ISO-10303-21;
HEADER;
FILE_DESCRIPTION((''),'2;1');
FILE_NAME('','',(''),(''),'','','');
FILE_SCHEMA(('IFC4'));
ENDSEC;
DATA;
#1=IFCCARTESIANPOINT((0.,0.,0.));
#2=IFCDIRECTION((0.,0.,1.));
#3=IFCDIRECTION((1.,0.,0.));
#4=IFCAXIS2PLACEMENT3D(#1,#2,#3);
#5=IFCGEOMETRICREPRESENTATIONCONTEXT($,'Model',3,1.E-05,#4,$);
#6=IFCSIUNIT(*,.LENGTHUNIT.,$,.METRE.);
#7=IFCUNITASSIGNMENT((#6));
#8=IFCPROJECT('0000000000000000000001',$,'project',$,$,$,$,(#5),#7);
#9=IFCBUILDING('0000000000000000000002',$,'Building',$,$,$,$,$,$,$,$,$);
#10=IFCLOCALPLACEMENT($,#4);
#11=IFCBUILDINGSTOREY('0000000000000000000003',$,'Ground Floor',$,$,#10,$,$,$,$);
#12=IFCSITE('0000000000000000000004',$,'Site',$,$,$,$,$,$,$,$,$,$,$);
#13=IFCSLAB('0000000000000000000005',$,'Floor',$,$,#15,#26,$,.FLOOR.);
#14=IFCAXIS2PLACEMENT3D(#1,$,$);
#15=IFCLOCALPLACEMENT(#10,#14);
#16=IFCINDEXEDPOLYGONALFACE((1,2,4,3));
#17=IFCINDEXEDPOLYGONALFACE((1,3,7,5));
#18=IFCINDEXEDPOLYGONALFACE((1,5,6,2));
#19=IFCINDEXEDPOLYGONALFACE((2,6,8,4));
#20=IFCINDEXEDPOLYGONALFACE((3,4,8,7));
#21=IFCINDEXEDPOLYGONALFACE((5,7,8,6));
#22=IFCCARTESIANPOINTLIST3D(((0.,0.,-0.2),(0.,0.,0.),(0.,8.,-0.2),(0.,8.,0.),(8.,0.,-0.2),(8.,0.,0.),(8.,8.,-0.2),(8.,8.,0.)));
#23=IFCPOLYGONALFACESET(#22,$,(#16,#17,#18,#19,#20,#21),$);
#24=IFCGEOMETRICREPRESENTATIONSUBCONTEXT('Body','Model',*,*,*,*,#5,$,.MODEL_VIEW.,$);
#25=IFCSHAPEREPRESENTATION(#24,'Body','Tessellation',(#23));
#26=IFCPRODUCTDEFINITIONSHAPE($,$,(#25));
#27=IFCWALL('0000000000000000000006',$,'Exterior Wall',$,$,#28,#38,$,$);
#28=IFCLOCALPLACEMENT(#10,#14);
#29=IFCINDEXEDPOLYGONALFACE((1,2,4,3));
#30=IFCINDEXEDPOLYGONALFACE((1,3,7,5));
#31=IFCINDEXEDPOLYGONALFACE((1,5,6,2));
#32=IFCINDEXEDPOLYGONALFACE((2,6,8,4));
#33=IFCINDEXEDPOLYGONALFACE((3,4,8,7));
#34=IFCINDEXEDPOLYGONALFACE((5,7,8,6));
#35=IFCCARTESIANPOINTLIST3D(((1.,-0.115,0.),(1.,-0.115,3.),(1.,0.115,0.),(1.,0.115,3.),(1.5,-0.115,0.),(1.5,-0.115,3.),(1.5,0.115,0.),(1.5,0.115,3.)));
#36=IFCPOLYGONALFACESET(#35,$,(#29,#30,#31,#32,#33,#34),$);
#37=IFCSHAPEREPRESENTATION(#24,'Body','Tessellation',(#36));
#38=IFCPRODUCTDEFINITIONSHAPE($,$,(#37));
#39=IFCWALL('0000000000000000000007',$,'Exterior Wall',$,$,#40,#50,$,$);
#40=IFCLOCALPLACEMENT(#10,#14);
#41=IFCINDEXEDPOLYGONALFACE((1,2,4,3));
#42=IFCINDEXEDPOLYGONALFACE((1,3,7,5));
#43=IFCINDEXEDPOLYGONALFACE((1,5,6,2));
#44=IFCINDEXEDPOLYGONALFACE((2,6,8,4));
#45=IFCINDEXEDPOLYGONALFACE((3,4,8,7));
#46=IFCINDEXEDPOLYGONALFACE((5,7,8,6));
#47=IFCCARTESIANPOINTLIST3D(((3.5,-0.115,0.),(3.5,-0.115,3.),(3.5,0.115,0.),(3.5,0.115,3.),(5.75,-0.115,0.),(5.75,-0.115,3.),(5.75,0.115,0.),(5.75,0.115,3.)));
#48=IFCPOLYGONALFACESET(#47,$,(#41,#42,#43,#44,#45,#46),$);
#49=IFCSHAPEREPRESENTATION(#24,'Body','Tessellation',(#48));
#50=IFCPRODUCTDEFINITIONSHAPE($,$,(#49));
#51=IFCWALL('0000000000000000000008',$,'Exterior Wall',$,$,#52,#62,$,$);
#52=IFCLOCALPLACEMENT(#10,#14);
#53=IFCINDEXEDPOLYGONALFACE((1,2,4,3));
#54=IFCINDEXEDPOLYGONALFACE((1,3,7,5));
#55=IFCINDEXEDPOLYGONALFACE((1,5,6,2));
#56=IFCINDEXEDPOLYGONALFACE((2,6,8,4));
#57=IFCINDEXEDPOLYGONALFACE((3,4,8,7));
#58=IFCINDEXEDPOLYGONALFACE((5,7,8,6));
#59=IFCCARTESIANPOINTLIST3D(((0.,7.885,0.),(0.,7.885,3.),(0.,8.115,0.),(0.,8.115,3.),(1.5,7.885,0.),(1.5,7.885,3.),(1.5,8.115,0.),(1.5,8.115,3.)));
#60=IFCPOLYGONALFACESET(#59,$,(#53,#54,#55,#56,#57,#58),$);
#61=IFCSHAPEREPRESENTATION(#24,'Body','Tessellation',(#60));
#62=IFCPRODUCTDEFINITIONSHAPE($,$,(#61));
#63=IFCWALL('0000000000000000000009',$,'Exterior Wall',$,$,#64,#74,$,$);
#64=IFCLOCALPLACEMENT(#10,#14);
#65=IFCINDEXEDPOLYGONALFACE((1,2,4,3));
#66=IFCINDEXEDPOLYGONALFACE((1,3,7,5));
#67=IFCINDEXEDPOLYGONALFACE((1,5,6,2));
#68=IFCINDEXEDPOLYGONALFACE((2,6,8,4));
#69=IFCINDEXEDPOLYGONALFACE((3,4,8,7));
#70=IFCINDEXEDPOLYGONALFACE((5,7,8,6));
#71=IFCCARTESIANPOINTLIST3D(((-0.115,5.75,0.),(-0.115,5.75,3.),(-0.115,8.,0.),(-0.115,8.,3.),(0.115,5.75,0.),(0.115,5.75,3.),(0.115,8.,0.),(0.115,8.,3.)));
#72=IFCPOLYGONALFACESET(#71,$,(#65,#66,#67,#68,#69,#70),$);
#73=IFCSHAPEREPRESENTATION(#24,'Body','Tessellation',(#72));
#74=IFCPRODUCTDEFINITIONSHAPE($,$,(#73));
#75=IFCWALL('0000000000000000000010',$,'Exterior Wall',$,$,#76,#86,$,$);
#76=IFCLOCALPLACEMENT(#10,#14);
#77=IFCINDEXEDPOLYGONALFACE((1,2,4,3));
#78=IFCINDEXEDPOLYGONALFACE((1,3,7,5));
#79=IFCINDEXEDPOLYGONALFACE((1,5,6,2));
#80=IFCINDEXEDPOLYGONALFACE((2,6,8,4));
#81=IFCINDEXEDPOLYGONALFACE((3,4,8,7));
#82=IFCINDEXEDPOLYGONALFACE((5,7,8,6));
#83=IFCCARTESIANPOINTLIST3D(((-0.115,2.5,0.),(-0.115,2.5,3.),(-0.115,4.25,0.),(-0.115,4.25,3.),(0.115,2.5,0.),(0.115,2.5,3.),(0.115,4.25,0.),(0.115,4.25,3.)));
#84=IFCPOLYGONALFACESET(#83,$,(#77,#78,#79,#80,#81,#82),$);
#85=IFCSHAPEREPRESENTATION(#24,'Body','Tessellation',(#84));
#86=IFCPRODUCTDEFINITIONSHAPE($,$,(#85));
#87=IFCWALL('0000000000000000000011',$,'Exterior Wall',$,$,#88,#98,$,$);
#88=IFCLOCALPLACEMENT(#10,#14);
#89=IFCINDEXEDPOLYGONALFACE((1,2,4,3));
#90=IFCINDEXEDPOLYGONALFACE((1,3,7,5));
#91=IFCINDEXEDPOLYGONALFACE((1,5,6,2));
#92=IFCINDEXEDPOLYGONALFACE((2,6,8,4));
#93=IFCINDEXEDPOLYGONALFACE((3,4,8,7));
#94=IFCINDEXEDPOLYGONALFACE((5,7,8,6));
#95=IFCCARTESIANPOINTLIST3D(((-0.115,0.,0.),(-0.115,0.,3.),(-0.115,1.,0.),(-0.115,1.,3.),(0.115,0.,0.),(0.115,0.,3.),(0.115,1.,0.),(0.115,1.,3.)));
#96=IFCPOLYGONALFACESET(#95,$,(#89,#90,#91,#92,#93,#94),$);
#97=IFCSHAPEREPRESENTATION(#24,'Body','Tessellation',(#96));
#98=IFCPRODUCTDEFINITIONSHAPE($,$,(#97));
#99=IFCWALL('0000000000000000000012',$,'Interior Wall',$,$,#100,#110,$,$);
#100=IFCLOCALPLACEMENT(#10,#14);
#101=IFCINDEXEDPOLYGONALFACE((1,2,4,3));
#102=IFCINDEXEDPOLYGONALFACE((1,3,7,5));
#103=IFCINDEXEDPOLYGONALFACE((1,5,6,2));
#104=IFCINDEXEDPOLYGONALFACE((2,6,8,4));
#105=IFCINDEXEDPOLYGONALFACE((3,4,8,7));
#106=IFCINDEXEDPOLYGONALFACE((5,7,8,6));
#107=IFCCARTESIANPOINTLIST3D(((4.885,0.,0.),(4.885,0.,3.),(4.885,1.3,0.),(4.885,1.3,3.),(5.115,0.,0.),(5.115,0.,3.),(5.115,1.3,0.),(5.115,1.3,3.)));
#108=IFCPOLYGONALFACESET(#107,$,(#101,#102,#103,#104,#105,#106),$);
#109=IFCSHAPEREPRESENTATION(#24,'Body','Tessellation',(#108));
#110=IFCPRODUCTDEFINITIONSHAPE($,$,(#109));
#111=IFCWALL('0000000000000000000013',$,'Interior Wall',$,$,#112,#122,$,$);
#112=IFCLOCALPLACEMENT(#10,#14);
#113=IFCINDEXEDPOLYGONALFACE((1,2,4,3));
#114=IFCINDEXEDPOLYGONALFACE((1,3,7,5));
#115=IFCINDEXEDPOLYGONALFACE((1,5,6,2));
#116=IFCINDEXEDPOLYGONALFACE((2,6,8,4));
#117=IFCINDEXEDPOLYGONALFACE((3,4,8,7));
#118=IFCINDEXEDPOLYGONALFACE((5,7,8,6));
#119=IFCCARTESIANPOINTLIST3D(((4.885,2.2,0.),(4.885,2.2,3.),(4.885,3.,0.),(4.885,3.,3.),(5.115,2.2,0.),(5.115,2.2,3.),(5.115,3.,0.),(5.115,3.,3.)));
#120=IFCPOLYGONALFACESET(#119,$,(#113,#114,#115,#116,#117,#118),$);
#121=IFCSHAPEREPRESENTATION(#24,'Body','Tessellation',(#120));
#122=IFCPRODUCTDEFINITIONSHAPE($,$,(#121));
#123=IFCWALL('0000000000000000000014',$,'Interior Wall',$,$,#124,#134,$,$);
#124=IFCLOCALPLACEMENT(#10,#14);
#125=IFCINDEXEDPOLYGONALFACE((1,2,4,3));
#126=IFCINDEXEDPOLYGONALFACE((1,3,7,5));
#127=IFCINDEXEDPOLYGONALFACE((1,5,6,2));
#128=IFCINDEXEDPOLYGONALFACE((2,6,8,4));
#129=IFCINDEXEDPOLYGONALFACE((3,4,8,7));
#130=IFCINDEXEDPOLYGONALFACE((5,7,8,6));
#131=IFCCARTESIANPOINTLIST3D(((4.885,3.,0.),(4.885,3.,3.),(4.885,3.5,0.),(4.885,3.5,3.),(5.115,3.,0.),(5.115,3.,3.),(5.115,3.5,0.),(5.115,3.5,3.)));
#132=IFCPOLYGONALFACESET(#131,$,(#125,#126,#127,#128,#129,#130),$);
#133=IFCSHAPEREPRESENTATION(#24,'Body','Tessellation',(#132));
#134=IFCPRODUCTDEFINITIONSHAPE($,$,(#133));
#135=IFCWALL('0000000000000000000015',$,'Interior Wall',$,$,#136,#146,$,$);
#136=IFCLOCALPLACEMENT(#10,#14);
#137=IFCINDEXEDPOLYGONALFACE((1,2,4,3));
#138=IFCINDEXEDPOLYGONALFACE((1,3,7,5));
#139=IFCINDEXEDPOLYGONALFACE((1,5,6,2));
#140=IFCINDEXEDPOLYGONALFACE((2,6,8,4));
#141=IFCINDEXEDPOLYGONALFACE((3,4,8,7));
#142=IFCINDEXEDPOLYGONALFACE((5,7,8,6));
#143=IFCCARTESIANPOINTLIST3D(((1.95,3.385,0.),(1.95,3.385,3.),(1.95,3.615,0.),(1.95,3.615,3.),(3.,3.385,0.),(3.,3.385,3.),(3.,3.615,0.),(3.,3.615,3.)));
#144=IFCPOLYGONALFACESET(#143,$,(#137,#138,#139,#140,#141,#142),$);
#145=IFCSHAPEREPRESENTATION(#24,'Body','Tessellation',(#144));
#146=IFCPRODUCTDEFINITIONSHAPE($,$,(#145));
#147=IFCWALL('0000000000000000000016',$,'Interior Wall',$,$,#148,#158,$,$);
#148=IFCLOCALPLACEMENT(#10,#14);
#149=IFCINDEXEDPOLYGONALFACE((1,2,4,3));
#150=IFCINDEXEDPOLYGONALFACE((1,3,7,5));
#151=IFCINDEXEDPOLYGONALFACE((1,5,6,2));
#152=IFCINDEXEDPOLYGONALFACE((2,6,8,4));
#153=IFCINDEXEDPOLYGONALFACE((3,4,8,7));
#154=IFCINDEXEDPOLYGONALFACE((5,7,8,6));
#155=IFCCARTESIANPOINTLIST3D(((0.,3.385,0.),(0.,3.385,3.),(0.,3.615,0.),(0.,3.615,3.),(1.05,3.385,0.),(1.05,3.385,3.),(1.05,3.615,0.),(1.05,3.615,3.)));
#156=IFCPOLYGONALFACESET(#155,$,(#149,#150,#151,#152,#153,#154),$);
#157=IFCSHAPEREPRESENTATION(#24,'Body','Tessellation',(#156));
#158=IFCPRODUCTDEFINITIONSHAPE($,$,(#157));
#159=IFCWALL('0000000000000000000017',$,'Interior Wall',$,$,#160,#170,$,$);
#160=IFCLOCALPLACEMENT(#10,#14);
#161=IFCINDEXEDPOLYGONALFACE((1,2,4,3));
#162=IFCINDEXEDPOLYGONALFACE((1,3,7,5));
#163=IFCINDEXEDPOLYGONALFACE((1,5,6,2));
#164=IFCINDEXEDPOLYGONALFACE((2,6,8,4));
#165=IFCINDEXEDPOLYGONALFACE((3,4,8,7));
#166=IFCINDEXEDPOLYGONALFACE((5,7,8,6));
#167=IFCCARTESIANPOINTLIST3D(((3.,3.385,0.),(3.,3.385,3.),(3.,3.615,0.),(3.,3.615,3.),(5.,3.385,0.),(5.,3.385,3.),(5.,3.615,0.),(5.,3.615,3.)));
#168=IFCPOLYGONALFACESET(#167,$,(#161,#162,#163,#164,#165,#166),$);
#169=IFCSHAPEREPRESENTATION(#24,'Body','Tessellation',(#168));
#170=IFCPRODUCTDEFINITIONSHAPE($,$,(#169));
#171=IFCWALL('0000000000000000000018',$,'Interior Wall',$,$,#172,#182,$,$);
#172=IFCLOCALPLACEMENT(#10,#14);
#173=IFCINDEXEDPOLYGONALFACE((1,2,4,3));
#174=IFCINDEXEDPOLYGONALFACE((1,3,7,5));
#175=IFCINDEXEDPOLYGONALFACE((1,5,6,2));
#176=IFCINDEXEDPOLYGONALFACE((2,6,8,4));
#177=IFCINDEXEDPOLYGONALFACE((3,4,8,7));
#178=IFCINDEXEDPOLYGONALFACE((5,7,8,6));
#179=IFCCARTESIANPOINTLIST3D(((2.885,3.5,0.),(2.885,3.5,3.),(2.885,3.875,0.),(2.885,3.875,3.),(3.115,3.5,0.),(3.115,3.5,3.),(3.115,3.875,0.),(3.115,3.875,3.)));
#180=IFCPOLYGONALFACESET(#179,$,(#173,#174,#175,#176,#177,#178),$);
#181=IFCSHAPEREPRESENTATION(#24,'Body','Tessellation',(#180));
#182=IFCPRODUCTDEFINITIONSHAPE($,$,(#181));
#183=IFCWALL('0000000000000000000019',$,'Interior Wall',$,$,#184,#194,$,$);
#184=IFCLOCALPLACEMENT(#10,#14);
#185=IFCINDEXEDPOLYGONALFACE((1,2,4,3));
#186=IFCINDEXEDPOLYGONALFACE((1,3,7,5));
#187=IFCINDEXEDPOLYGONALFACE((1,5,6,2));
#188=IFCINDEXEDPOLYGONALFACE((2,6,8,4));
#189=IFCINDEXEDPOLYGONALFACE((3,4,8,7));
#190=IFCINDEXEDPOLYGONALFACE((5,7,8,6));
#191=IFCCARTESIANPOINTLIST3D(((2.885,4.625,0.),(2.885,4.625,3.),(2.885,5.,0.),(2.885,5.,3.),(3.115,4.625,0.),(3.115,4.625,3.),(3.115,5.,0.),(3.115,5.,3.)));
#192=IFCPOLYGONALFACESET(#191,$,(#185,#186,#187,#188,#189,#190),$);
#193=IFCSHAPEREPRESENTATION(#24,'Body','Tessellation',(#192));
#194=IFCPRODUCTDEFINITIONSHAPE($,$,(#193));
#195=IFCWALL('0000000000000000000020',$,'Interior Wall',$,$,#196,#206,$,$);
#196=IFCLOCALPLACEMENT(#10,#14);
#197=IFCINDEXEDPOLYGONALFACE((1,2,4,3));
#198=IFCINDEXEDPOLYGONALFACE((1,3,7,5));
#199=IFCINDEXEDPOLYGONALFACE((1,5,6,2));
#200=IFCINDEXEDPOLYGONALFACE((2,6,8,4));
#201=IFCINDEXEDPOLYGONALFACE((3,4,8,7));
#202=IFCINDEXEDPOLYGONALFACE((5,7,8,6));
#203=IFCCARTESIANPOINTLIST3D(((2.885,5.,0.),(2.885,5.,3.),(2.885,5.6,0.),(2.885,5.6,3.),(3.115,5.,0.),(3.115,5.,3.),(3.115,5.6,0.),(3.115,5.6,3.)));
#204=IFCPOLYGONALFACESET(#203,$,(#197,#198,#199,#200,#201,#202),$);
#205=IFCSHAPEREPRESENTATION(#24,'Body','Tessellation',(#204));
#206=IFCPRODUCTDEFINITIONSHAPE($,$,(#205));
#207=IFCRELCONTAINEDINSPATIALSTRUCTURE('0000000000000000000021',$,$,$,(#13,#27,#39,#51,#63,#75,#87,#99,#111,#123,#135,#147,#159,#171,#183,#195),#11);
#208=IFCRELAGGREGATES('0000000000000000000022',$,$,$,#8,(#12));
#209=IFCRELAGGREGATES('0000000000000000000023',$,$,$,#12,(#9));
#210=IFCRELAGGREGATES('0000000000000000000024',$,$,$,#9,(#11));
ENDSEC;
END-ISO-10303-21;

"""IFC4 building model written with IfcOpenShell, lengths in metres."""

from ifc_helpers import new_model, si_unit, frame, origin_with_axes, place, context, subcontext, project, spatial, indexed_curve, outline, extrude, element, save


model = new_model("IFC4")

# Units and contexts
model_context = context("Model", 3, precision=1e-05, world=origin_with_axes())
body_context = subcontext(model_context, "Body", "Model", "MODEL_VIEW")
ifc_project = project(units=[si_unit("LENGTHUNIT", "METRE")], contexts=[model_context])

# Site, building, storey
site = spatial("IfcSite", under=ifc_project, Name="Site")
building = spatial("IfcBuilding", under=site, Name="Building")
storey_placement = place(None, origin_with_axes())
storey = spatial("IfcBuildingStorey", under=building, at=storey_placement, Name="Ground Floor")

# Slab
slab_placement = place(storey_placement, frame((0.0, 0.0, -0.2), z_axis=(0.0, 0.0, 1.0), x_axis=(1.0, 0.0, 0.0)))
element("IfcSlab", 1, at=slab_placement, inside=storey, Name="Floor", PredefinedType="FLOOR", context=body_context, shape_type="SweptSolid", body=[
    extrude(outline(indexed_curve([(0.0, 0.0), (8.0, 0.0), (8.0, 8.0), (0.0, 8.0)])), None, (0.0, 0.0, 1.0), 0.2),
])

# Walls
wall_1_placement = place(storey_placement, frame((1.0, 0.0, 0.0), z_axis=(0.0, 0.0, 1.0), x_axis=(1.0, 0.0, 0.0)))
element("IfcWall", 2, at=wall_1_placement, inside=storey, Name="Exterior Wall", context=body_context, shape_type="SweptSolid", body=[
    extrude(outline(indexed_curve([(0.0, 0.0), (0.0, 0.23), (0.5, 0.23), (0.5, 0.0), (0.0, 0.0)], self_intersect=False)), frame((0.0, -0.115, 0.0), z_axis=(0.0, 0.0, 1.0), x_axis=(1.0, 0.0, 0.0)), (0.0, 0.0, 1.0), 3.0),
])
wall_2_placement = place(storey_placement, frame((3.5, 0.0, 0.0), z_axis=(0.0, 0.0, 1.0), x_axis=(1.0, 0.0, 0.0)))
element("IfcWall", 3, at=wall_2_placement, inside=storey, Name="Exterior Wall", context=body_context, shape_type="SweptSolid", body=[
    extrude(outline(indexed_curve([(0.0, 0.0), (0.0, 0.23), (2.25, 0.23), (2.25, 0.0), (0.0, 0.0)], self_intersect=False)), frame((0.0, -0.115, 0.0), z_axis=(0.0, 0.0, 1.0), x_axis=(1.0, 0.0, 0.0)), (0.0, 0.0, 1.0), 3.0),
])
wall_3_placement = place(storey_placement, frame((1.5, 8.0, 0.0), z_axis=(0.0, 0.0, 1.0), x_axis=(-1.0, 0.0, 0.0)))
element("IfcWall", 4, at=wall_3_placement, inside=storey, Name="Exterior Wall", context=body_context, shape_type="SweptSolid", body=[
    extrude(outline(indexed_curve([(0.0, 0.0), (0.0, 0.23), (1.5, 0.23), (1.5, 0.0), (0.0, 0.0)], self_intersect=False)), frame((0.0, -0.115, 0.0), z_axis=(0.0, 0.0, 1.0), x_axis=(1.0, 0.0, 0.0)), (0.0, 0.0, 1.0), 3.0),
])
wall_4_placement = place(storey_placement, frame((0.0, 8.0, 0.0), z_axis=(0.0, 0.0, 1.0), x_axis=(0.0, -1.0, 0.0)))
element("IfcWall", 5, at=wall_4_placement, inside=storey, Name="Exterior Wall", context=body_context, shape_type="SweptSolid", body=[
    extrude(outline(indexed_curve([(0.0, 0.0), (0.0, 0.23), (2.25, 0.23), (2.25, 0.0), (0.0, 0.0)], self_intersect=False)), frame((0.0, -0.115, 0.0), z_axis=(0.0, 0.0, 1.0), x_axis=(1.0, 0.0, 0.0)), (0.0, 0.0, 1.0), 3.0),
])
wall_5_placement = place(storey_placement, frame((0.0, 4.25, 0.0), z_axis=(0.0, 0.0, 1.0), x_axis=(0.0, -1.0, 0.0)))
element("IfcWall", 6, at=wall_5_placement, inside=storey, Name="Exterior Wall", context=body_context, shape_type="SweptSolid", body=[
    extrude(outline(indexed_curve([(0.0, 0.0), (0.0, 0.23), (1.75, 0.23), (1.75, 0.0), (0.0, 0.0)], self_intersect=False)), frame((0.0, -0.115, 0.0), z_axis=(0.0, 0.0, 1.0), x_axis=(1.0, 0.0, 0.0)), (0.0, 0.0, 1.0), 3.0),
])
wall_6_placement = place(storey_placement, frame((0.0, 1.0, 0.0), z_axis=(0.0, 0.0, 1.0), x_axis=(0.0, -1.0, 0.0)))
element("IfcWall", 7, at=wall_6_placement, inside=storey, Name="Exterior Wall", context=body_context, shape_type="SweptSolid", body=[
    extrude(outline(indexed_curve([(0.0, 0.0), (0.0, 0.23), (1.0, 0.23), (1.0, 0.0), (0.0, 0.0)], self_intersect=False)), frame((0.0, -0.115, 0.0), z_axis=(0.0, 0.0, 1.0), x_axis=(1.0, 0.0, 0.0)), (0.0, 0.0, 1.0), 3.0),
])
wall_7_placement = place(storey_placement, frame((5.0, 0.0, 0.0), z_axis=(0.0, 0.0, 1.0), x_axis=(0.0, 1.0, 0.0)))
element("IfcWall", 8, at=wall_7_placement, inside=storey, Name="Interior Wall", context=body_context, shape_type="SweptSolid", body=[
    extrude(outline(indexed_curve([(0.0, 0.0), (0.0, 0.23), (1.3, 0.23), (1.3, 0.0), (0.0, 0.0)], self_intersect=False)), frame((0.0, -0.115, 0.0), z_axis=(0.0, 0.0, 1.0), x_axis=(1.0, 0.0, 0.0)), (0.0, 0.0, 1.0), 3.0),
])
wall_8_placement = place(storey_placement, frame((5.0, 2.2, 0.0), z_axis=(0.0, 0.0, 1.0), x_axis=(0.0, 1.0, 0.0)))
element("IfcWall", 9, at=wall_8_placement, inside=storey, Name="Interior Wall", context=body_context, shape_type="SweptSolid", body=[
    extrude(outline(indexed_curve([(0.0, 0.0), (0.0, 0.23), (0.8, 0.23), (0.8, 0.0), (0.0, 0.0)], self_intersect=False)), frame((0.0, -0.115, 0.0), z_axis=(0.0, 0.0, 1.0), x_axis=(1.0, 0.0, 0.0)), (0.0, 0.0, 1.0), 3.0),
])
wall_9_placement = place(storey_placement, frame((5.0, 3.0, 0.0), z_axis=(0.0, 0.0, 1.0), x_axis=(0.0, 1.0, 0.0)))
element("IfcWall", 10, at=wall_9_placement, inside=storey, Name="Interior Wall", context=body_context, shape_type="SweptSolid", body=[
    extrude(outline(indexed_curve([(0.0, 0.0), (0.0, 0.23), (0.5, 0.23), (0.5, 0.0), (0.0, 0.0)], self_intersect=False)), frame((0.0, -0.115, 0.0), z_axis=(0.0, 0.0, 1.0), x_axis=(1.0, 0.0, 0.0)), (0.0, 0.0, 1.0), 3.0),
])
for number, where, z_axis, x_axis, name in (
    (11, (3.0, 3.5, 0.0), (0.0, 0.0, 1.0), (-1.0, 0.0, 0.0), "Interior Wall"),
    (12, (1.05, 3.5, 0.0), (0.0, 0.0, 1.0), (-1.0, 0.0, 0.0), "Interior Wall"),
):
    element("IfcWall", number, at=place(storey_placement, frame(where, z_axis=z_axis, x_axis=x_axis)), inside=storey, Name=name, context=body_context, shape_type="SweptSolid", body=[
        extrude(outline(indexed_curve([(0.0, 0.0), (0.0, 0.23), (1.05, 0.23), (1.05, 0.0), (0.0, 0.0)], self_intersect=False)), frame((0.0, -0.115, 0.0), z_axis=(0.0, 0.0, 1.0), x_axis=(1.0, 0.0, 0.0)), (0.0, 0.0, 1.0), 3.0),
    ])
wall_10_placement = place(storey_placement, frame((5.0, 3.5, 0.0), z_axis=(0.0, 0.0, 1.0), x_axis=(-1.0, 0.0, 0.0)))
element("IfcWall", 13, at=wall_10_placement, inside=storey, Name="Interior Wall", context=body_context, shape_type="SweptSolid", body=[
    extrude(outline(indexed_curve([(0.0, 0.0), (0.0, 0.23), (2.0, 0.23), (2.0, 0.0), (0.0, 0.0)], self_intersect=False)), frame((0.0, -0.115, 0.0), z_axis=(0.0, 0.0, 1.0), x_axis=(1.0, 0.0, 0.0)), (0.0, 0.0, 1.0), 3.0),
])
for number, where, z_axis, x_axis, name in (
    (14, (3.0, 3.5, 0.0), (0.0, 0.0, 1.0), (0.0, 1.0, 0.0), "Interior Wall"),
    (15, (3.0, 4.625, 0.0), (0.0, 0.0, 1.0), (0.0, 1.0, 0.0), "Interior Wall"),
):
    element("IfcWall", number, at=place(storey_placement, frame(where, z_axis=z_axis, x_axis=x_axis)), inside=storey, Name=name, context=body_context, shape_type="SweptSolid", body=[
        extrude(outline(indexed_curve([(0.0, 0.0), (0.0, 0.23), (0.375, 0.23), (0.375, 0.0), (0.0, 0.0)], self_intersect=False)), frame((0.0, -0.115, 0.0), z_axis=(0.0, 0.0, 1.0), x_axis=(1.0, 0.0, 0.0)), (0.0, 0.0, 1.0), 3.0),
    ])
for number, where, z_axis, x_axis, name in (
    (16, (3.0, 5.0, 0.0), (0.0, 0.0, 1.0), (0.0, 1.0, 0.0), "Interior Wall"),
):
    element("IfcWall", number, at=place(storey_placement, frame(where, z_axis=z_axis, x_axis=x_axis)), inside=storey, Name=name, context=body_context, shape_type="SweptSolid", body=[
        extrude(outline(indexed_curve([(0.0, 0.0), (0.0, 0.23), (0.6, 0.23), (0.6, 0.0), (0.0, 0.0)], self_intersect=False)), frame((0.0, -0.115, 0.0), z_axis=(0.0, 0.0, 1.0), x_axis=(1.0, 0.0, 0.0)), (0.0, 0.0, 1.0), 3.0),
    ])

save(model, "model.ifc")
